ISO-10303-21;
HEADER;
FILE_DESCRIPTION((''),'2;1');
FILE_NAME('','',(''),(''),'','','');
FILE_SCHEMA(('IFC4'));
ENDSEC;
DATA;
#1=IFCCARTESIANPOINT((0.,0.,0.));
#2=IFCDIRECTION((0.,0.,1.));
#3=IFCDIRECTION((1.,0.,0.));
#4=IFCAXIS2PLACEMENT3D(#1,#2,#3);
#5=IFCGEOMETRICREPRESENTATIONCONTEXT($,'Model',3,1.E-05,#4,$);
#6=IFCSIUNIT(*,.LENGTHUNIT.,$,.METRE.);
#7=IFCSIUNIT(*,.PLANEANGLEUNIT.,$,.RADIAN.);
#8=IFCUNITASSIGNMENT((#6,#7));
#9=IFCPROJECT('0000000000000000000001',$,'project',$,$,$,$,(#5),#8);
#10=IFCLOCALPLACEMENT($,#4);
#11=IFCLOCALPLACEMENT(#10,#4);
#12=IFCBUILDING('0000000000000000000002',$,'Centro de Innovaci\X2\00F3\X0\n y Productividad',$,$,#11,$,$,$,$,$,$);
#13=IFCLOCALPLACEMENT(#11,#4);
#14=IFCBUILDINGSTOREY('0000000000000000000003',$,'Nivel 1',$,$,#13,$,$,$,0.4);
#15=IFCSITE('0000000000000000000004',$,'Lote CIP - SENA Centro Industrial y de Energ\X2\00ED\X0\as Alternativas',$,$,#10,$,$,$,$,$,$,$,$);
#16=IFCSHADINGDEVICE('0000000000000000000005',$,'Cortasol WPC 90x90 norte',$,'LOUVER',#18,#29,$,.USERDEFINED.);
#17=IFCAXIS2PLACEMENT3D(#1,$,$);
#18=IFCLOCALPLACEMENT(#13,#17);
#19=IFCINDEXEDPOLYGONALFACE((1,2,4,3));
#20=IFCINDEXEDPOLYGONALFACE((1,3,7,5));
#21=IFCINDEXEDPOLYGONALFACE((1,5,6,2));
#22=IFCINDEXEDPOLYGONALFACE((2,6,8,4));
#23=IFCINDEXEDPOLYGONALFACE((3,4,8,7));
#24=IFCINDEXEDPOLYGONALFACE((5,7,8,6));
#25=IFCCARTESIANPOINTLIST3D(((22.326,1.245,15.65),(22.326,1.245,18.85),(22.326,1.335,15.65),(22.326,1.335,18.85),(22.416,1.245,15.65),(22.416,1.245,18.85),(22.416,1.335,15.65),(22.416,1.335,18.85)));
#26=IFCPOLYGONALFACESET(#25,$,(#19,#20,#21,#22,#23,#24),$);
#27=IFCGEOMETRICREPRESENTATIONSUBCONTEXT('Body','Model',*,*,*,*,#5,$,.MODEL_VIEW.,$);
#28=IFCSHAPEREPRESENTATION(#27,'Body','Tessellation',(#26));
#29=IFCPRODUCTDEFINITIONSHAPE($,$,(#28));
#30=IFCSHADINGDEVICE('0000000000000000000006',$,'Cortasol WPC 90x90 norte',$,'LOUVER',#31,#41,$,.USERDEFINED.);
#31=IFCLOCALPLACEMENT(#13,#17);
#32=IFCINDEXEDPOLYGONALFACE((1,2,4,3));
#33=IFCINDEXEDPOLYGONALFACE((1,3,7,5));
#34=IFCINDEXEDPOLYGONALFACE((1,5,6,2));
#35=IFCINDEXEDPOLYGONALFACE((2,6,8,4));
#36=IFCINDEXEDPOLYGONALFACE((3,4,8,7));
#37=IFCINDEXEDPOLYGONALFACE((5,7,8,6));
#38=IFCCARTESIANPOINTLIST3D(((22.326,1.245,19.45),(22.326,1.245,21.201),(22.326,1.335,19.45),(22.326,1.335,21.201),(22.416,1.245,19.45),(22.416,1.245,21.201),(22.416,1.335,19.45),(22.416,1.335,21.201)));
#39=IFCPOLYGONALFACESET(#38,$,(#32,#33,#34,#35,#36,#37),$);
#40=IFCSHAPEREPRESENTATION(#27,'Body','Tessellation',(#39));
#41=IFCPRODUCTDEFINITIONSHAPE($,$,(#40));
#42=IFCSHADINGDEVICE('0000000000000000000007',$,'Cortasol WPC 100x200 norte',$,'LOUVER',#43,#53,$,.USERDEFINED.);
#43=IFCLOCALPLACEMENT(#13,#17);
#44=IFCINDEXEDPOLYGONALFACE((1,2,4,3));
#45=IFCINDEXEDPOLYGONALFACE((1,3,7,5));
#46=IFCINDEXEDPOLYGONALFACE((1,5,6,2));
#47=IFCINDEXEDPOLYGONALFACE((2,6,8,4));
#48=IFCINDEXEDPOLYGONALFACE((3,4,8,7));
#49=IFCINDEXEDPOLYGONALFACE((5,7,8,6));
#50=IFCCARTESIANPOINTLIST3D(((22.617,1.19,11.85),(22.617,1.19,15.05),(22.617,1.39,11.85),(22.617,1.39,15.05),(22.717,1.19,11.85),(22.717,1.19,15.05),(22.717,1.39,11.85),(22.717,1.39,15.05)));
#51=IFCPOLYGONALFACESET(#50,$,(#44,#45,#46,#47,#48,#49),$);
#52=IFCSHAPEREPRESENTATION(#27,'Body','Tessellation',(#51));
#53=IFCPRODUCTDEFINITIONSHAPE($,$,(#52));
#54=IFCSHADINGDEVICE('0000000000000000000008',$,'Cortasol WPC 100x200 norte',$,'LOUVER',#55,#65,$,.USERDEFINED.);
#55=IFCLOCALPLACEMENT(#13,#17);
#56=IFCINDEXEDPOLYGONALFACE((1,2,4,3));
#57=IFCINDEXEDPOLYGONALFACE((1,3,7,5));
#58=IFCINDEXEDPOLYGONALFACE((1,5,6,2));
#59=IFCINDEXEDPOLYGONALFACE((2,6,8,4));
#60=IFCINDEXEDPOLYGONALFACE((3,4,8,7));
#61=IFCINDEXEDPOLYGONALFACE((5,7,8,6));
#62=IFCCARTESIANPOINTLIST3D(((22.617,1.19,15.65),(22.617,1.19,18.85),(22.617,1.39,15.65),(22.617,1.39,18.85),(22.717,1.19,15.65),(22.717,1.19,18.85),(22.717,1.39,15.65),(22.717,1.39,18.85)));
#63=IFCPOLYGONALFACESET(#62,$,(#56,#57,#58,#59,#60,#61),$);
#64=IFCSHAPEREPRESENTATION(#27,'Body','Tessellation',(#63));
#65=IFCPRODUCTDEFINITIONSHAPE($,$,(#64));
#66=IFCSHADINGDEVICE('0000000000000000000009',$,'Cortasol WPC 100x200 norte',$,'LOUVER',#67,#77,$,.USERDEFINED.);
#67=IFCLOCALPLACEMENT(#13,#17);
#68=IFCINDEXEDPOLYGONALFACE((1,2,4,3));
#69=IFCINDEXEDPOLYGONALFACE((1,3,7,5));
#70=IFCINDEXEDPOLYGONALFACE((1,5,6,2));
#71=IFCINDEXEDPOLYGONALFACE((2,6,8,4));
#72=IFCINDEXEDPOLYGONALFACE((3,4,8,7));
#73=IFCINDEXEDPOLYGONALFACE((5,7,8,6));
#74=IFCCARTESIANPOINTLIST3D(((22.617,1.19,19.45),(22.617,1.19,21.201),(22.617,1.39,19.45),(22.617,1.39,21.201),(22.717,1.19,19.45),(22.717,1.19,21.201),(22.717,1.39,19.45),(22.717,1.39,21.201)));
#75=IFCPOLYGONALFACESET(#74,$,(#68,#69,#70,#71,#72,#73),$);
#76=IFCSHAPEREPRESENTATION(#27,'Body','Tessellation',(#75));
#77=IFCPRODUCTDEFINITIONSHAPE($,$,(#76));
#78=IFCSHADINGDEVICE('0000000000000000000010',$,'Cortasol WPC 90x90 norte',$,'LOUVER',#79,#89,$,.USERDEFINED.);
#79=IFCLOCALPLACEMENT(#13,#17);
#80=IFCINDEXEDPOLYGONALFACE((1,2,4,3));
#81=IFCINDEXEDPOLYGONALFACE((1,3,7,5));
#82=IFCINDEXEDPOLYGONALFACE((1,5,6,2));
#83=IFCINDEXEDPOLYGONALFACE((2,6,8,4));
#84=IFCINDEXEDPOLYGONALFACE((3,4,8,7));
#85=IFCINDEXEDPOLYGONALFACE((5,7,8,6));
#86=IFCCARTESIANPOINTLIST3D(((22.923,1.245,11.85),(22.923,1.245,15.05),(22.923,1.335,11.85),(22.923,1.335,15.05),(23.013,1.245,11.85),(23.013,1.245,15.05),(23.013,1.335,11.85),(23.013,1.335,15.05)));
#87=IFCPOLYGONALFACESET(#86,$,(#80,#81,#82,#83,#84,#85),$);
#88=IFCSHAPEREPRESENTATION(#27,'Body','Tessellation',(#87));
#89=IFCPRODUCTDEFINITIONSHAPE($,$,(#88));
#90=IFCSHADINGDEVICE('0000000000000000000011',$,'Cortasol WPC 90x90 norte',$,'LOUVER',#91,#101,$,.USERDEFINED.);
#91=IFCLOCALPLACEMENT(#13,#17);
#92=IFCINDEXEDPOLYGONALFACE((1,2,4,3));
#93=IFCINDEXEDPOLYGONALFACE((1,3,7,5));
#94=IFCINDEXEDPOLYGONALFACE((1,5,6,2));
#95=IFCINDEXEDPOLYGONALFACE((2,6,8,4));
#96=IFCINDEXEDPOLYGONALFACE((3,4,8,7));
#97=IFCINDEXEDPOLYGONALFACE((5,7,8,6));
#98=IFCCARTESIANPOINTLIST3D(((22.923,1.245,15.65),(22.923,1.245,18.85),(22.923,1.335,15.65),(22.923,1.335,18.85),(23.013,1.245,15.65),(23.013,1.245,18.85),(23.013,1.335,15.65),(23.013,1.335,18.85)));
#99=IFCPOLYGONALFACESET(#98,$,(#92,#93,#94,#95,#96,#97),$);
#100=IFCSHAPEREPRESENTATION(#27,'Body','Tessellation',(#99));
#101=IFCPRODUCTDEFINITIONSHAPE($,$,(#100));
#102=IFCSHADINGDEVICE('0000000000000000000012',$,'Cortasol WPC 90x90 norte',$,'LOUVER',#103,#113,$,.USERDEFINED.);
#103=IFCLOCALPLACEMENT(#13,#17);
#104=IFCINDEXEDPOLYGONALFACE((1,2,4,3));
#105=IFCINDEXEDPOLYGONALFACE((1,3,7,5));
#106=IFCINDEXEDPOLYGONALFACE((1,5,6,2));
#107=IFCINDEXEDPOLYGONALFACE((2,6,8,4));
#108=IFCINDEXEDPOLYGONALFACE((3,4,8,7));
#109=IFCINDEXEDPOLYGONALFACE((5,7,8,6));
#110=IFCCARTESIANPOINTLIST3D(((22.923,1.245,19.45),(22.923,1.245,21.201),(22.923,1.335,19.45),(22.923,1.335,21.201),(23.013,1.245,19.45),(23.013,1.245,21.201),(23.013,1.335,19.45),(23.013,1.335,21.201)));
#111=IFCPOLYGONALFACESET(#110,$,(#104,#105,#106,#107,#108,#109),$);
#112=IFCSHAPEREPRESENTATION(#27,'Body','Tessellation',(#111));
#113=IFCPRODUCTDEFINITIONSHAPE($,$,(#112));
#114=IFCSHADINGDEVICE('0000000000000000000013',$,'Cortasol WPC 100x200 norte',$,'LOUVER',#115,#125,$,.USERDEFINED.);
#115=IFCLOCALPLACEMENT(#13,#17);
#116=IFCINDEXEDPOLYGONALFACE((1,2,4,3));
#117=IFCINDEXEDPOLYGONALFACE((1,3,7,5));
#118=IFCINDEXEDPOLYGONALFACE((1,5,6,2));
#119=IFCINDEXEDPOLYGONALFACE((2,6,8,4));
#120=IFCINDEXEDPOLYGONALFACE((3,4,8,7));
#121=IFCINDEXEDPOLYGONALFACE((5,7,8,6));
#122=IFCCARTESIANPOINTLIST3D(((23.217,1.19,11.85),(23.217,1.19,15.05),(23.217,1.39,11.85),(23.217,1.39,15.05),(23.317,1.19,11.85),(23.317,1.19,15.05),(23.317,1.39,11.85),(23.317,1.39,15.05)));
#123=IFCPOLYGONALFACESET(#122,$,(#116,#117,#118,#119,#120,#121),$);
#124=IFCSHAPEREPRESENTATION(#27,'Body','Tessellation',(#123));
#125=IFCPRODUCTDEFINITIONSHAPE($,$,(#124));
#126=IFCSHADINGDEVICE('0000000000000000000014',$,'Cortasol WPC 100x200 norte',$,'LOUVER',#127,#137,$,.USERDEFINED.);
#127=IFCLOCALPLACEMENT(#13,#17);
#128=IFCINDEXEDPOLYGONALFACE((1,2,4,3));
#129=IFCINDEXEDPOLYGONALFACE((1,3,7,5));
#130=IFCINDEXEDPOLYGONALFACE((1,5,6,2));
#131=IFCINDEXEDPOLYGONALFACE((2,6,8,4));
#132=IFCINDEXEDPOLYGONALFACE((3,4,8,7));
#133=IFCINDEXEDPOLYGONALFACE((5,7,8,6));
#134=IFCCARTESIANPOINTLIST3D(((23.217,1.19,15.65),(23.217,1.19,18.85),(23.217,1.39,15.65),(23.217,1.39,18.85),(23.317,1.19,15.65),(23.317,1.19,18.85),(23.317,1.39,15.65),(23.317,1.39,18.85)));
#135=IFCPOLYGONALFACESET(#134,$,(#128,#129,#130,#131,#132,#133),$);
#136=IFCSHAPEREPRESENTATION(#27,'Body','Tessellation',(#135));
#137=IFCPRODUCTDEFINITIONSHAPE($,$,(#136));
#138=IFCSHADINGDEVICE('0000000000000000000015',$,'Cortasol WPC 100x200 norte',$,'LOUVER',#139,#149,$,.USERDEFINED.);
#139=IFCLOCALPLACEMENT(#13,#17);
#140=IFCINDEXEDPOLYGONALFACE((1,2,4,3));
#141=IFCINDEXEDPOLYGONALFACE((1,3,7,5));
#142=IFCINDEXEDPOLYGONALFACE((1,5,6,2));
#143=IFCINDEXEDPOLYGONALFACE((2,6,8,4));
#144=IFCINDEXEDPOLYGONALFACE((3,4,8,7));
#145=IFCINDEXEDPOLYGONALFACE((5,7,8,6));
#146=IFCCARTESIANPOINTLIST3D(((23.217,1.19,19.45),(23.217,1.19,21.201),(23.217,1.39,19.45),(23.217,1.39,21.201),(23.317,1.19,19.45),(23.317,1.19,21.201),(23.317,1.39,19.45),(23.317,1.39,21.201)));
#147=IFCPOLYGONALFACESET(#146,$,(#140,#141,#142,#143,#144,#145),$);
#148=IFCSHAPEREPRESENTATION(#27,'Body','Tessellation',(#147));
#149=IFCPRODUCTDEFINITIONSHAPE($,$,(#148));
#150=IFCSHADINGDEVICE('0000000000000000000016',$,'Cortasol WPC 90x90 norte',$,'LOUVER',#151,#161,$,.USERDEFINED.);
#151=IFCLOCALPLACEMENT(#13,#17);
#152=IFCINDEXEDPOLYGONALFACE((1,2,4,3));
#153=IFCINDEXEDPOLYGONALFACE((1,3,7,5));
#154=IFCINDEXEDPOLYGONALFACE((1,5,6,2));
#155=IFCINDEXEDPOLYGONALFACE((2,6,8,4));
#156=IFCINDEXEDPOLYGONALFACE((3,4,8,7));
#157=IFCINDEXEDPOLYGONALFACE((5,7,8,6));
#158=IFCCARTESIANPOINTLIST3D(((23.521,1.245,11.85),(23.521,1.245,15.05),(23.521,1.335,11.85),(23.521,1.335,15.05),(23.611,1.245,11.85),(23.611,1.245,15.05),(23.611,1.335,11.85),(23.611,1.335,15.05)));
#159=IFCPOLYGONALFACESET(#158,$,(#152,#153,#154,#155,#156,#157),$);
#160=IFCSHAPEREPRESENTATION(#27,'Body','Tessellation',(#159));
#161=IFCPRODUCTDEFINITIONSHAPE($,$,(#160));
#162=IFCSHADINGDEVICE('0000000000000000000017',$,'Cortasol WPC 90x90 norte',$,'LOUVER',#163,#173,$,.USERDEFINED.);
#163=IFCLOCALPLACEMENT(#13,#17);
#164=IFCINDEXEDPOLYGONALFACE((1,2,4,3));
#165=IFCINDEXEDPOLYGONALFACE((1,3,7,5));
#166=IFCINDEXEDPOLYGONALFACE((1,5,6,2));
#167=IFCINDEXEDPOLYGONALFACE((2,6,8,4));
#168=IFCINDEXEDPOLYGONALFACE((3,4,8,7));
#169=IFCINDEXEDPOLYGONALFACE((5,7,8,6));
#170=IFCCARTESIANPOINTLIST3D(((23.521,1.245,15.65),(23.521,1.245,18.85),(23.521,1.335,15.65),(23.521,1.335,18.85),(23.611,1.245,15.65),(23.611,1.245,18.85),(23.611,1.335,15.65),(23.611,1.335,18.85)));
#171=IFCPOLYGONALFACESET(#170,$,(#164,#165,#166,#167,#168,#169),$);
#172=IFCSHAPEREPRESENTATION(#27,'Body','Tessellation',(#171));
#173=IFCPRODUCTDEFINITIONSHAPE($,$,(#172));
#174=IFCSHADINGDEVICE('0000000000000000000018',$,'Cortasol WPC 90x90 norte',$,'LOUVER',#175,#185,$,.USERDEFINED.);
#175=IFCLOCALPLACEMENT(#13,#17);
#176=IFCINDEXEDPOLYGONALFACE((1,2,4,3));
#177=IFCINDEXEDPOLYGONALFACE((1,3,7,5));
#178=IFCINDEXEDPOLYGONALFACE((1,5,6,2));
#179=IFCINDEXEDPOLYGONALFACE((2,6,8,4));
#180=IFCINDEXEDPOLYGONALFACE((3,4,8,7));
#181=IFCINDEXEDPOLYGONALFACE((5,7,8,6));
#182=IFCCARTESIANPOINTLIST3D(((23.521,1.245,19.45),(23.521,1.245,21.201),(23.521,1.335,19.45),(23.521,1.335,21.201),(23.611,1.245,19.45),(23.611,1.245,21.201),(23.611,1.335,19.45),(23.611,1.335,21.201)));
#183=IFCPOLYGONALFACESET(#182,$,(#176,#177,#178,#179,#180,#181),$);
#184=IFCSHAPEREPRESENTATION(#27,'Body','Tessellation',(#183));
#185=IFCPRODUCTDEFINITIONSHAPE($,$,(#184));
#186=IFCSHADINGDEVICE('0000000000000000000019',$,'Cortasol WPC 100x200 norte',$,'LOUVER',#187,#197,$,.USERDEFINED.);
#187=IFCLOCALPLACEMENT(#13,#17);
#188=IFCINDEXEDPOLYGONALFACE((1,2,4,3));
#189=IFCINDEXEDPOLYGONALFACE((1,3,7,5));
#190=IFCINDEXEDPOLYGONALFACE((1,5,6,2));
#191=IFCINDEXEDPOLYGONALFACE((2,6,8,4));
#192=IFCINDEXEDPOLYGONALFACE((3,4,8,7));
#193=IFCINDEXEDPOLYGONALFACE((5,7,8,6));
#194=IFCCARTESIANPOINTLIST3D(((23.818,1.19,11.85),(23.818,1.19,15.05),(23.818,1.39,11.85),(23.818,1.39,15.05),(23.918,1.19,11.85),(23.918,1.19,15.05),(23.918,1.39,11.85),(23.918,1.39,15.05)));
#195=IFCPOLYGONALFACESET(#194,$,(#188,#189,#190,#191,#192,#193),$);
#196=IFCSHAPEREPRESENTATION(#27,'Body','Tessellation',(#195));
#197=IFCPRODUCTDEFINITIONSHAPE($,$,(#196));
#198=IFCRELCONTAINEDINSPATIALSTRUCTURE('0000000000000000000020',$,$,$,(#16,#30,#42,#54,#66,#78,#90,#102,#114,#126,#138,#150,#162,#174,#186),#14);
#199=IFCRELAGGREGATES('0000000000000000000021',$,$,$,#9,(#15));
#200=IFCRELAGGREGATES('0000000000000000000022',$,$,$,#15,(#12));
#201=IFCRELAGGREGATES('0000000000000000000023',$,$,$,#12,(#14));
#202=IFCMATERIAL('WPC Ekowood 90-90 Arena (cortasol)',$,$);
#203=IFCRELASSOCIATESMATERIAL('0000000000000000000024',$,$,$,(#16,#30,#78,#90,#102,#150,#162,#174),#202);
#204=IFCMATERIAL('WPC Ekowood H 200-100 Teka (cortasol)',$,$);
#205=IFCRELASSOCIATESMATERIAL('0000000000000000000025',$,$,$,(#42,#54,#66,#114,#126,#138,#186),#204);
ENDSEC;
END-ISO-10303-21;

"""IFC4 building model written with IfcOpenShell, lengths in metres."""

from ifc_helpers import new_model, si_unit, frame, origin_with_axes, place, context, subcontext, project, spatial, polyline, outline, extrude, material, element, save


model = new_model("IFC4")

# Units and contexts
model_context = context("Model", 3, precision=1e-05, world=origin_with_axes())
body_context = subcontext(model_context, "Body", "Model", "MODEL_VIEW")
ifc_project = project(units=[si_unit("LENGTHUNIT", "METRE"), si_unit("PLANEANGLEUNIT", "RADIAN")], contexts=[model_context])

# Site, building, storey
site_placement = place(None, origin_with_axes())
site = spatial("IfcSite", under=ifc_project, at=site_placement, Name="Lote CIP - SENA Centro Industrial y de Energías Alternativas")
building_placement = place(site_placement, origin_with_axes())
building = spatial("IfcBuilding", under=site, at=building_placement, Name="Centro de Innovación y Productividad")
storey_placement = place(building_placement, origin_with_axes())
storey = spatial("IfcBuildingStorey", under=building, at=storey_placement, Name="Nivel 1", Elevation=0.4)

# Shading devices
ifc_material_1 = material(Name="WPC Ekowood 90-90 Arena (cortasol)")
shading_device_1_placement = place(storey_placement, origin_with_axes())
element("IfcShadingDevice", 1, at=shading_device_1_placement, inside=storey, material=ifc_material_1, Name="Cortasol WPC 90x90 norte", ObjectType="LOUVER", PredefinedType="USERDEFINED", context=body_context, shape_type="SweptSolid", body=[
    extrude(outline(polyline([(22.326, 1.245), (22.326, 1.335), (22.416, 1.335), (22.416, 1.245), (22.326, 1.245)])), frame((0.0, 0.0, 15.65)), (0.0, 0.0, 1.0), 3.2),
])
shading_device_2_placement = place(storey_placement, origin_with_axes())
element("IfcShadingDevice", 2, at=shading_device_2_placement, inside=storey, material=ifc_material_1, Name="Cortasol WPC 90x90 norte", ObjectType="LOUVER", PredefinedType="USERDEFINED", context=body_context, shape_type="SweptSolid", body=[
    extrude(outline(polyline([(22.326, 1.245), (22.326, 1.335), (22.416, 1.335), (22.416, 1.245), (22.326, 1.245)])), frame((0.0, 0.0, 19.45)), (0.0, 0.0, 1.0), 1.751),
])
ifc_material_2 = material(Name="WPC Ekowood H 200-100 Teka (cortasol)")
shading_device_3_placement = place(storey_placement, origin_with_axes())
element("IfcShadingDevice", 3, at=shading_device_3_placement, inside=storey, material=ifc_material_2, Name="Cortasol WPC 100x200 norte", ObjectType="LOUVER", PredefinedType="USERDEFINED", context=body_context, shape_type="SweptSolid", body=[
    extrude(outline(polyline([(22.617, 1.19), (22.617, 1.39), (22.717, 1.39), (22.717, 1.19), (22.617, 1.19)])), frame((0.0, 0.0, 11.85)), (0.0, 0.0, 1.0), 3.2),
])
shading_device_4_placement = place(storey_placement, origin_with_axes())
element("IfcShadingDevice", 4, at=shading_device_4_placement, inside=storey, material=ifc_material_2, Name="Cortasol WPC 100x200 norte", ObjectType="LOUVER", PredefinedType="USERDEFINED", context=body_context, shape_type="SweptSolid", body=[
    extrude(outline(polyline([(22.617, 1.19), (22.617, 1.39), (22.717, 1.39), (22.717, 1.19), (22.617, 1.19)])), frame((0.0, 0.0, 15.65)), (0.0, 0.0, 1.0), 3.2),
])
shading_device_5_placement = place(storey_placement, origin_with_axes())
element("IfcShadingDevice", 5, at=shading_device_5_placement, inside=storey, material=ifc_material_2, Name="Cortasol WPC 100x200 norte", ObjectType="LOUVER", PredefinedType="USERDEFINED", context=body_context, shape_type="SweptSolid", body=[
    extrude(outline(polyline([(22.617, 1.19), (22.617, 1.39), (22.717, 1.39), (22.717, 1.19), (22.617, 1.19)])), frame((0.0, 0.0, 19.45)), (0.0, 0.0, 1.0), 1.751),
])
shading_device_6_placement = place(storey_placement, origin_with_axes())
element("IfcShadingDevice", 6, at=shading_device_6_placement, inside=storey, material=ifc_material_1, Name="Cortasol WPC 90x90 norte", ObjectType="LOUVER", PredefinedType="USERDEFINED", context=body_context, shape_type="SweptSolid", body=[
    extrude(outline(polyline([(22.923, 1.245), (22.923, 1.335), (23.013, 1.335), (23.013, 1.245), (22.923, 1.245)])), frame((0.0, 0.0, 11.85)), (0.0, 0.0, 1.0), 3.2),
])
shading_device_7_placement = place(storey_placement, origin_with_axes())
element("IfcShadingDevice", 7, at=shading_device_7_placement, inside=storey, material=ifc_material_1, Name="Cortasol WPC 90x90 norte", ObjectType="LOUVER", PredefinedType="USERDEFINED", context=body_context, shape_type="SweptSolid", body=[
    extrude(outline(polyline([(22.923, 1.245), (22.923, 1.335), (23.013, 1.335), (23.013, 1.245), (22.923, 1.245)])), frame((0.0, 0.0, 15.65)), (0.0, 0.0, 1.0), 3.2),
])
shading_device_8_placement = place(storey_placement, origin_with_axes())
element("IfcShadingDevice", 8, at=shading_device_8_placement, inside=storey, material=ifc_material_1, Name="Cortasol WPC 90x90 norte", ObjectType="LOUVER", PredefinedType="USERDEFINED", context=body_context, shape_type="SweptSolid", body=[
    extrude(outline(polyline([(22.923, 1.245), (22.923, 1.335), (23.013, 1.335), (23.013, 1.245), (22.923, 1.245)])), frame((0.0, 0.0, 19.45)), (0.0, 0.0, 1.0), 1.751),
])
shading_device_9_placement = place(storey_placement, origin_with_axes())
element("IfcShadingDevice", 9, at=shading_device_9_placement, inside=storey, material=ifc_material_2, Name="Cortasol WPC 100x200 norte", ObjectType="LOUVER", PredefinedType="USERDEFINED", context=body_context, shape_type="SweptSolid", body=[
    extrude(outline(polyline([(23.217, 1.19), (23.217, 1.39), (23.317, 1.39), (23.317, 1.19), (23.217, 1.19)])), frame((0.0, 0.0, 11.85)), (0.0, 0.0, 1.0), 3.2),
])
shading_device_10_placement = place(storey_placement, origin_with_axes())
element("IfcShadingDevice", 10, at=shading_device_10_placement, inside=storey, material=ifc_material_2, Name="Cortasol WPC 100x200 norte", ObjectType="LOUVER", PredefinedType="USERDEFINED", context=body_context, shape_type="SweptSolid", body=[
    extrude(outline(polyline([(23.217, 1.19), (23.217, 1.39), (23.317, 1.39), (23.317, 1.19), (23.217, 1.19)])), frame((0.0, 0.0, 15.65)), (0.0, 0.0, 1.0), 3.2),
])
shading_device_11_placement = place(storey_placement, origin_with_axes())
element("IfcShadingDevice", 11, at=shading_device_11_placement, inside=storey, material=ifc_material_2, Name="Cortasol WPC 100x200 norte", ObjectType="LOUVER", PredefinedType="USERDEFINED", context=body_context, shape_type="SweptSolid", body=[
    extrude(outline(polyline([(23.217, 1.19), (23.217, 1.39), (23.317, 1.39), (23.317, 1.19), (23.217, 1.19)])), frame((0.0, 0.0, 19.45)), (0.0, 0.0, 1.0), 1.751),
])
shading_device_12_placement = place(storey_placement, origin_with_axes())
element("IfcShadingDevice", 12, at=shading_device_12_placement, inside=storey, material=ifc_material_1, Name="Cortasol WPC 90x90 norte", ObjectType="LOUVER", PredefinedType="USERDEFINED", context=body_context, shape_type="SweptSolid", body=[
    extrude(outline(polyline([(23.521, 1.245), (23.521, 1.335), (23.611, 1.335), (23.611, 1.245), (23.521, 1.245)])), frame((0.0, 0.0, 11.85)), (0.0, 0.0, 1.0), 3.2),
])
shading_device_13_placement = place(storey_placement, origin_with_axes())
element("IfcShadingDevice", 13, at=shading_device_13_placement, inside=storey, material=ifc_material_1, Name="Cortasol WPC 90x90 norte", ObjectType="LOUVER", PredefinedType="USERDEFINED", context=body_context, shape_type="SweptSolid", body=[
    extrude(outline(polyline([(23.521, 1.245), (23.521, 1.335), (23.611, 1.335), (23.611, 1.245), (23.521, 1.245)])), frame((0.0, 0.0, 15.65)), (0.0, 0.0, 1.0), 3.2),
])
shading_device_14_placement = place(storey_placement, origin_with_axes())
element("IfcShadingDevice", 14, at=shading_device_14_placement, inside=storey, material=ifc_material_1, Name="Cortasol WPC 90x90 norte", ObjectType="LOUVER", PredefinedType="USERDEFINED", context=body_context, shape_type="SweptSolid", body=[
    extrude(outline(polyline([(23.521, 1.245), (23.521, 1.335), (23.611, 1.335), (23.611, 1.245), (23.521, 1.245)])), frame((0.0, 0.0, 19.45)), (0.0, 0.0, 1.0), 1.751),
])
shading_device_15_placement = place(storey_placement, origin_with_axes())
element("IfcShadingDevice", 15, at=shading_device_15_placement, inside=storey, material=ifc_material_2, Name="Cortasol WPC 100x200 norte", ObjectType="LOUVER", PredefinedType="USERDEFINED", context=body_context, shape_type="SweptSolid", body=[
    extrude(outline(polyline([(23.818, 1.19), (23.818, 1.39), (23.918, 1.39), (23.918, 1.19), (23.818, 1.19)])), frame((0.0, 0.0, 11.85)), (0.0, 0.0, 1.0), 3.2),
])

save(model, "model.ifc")
